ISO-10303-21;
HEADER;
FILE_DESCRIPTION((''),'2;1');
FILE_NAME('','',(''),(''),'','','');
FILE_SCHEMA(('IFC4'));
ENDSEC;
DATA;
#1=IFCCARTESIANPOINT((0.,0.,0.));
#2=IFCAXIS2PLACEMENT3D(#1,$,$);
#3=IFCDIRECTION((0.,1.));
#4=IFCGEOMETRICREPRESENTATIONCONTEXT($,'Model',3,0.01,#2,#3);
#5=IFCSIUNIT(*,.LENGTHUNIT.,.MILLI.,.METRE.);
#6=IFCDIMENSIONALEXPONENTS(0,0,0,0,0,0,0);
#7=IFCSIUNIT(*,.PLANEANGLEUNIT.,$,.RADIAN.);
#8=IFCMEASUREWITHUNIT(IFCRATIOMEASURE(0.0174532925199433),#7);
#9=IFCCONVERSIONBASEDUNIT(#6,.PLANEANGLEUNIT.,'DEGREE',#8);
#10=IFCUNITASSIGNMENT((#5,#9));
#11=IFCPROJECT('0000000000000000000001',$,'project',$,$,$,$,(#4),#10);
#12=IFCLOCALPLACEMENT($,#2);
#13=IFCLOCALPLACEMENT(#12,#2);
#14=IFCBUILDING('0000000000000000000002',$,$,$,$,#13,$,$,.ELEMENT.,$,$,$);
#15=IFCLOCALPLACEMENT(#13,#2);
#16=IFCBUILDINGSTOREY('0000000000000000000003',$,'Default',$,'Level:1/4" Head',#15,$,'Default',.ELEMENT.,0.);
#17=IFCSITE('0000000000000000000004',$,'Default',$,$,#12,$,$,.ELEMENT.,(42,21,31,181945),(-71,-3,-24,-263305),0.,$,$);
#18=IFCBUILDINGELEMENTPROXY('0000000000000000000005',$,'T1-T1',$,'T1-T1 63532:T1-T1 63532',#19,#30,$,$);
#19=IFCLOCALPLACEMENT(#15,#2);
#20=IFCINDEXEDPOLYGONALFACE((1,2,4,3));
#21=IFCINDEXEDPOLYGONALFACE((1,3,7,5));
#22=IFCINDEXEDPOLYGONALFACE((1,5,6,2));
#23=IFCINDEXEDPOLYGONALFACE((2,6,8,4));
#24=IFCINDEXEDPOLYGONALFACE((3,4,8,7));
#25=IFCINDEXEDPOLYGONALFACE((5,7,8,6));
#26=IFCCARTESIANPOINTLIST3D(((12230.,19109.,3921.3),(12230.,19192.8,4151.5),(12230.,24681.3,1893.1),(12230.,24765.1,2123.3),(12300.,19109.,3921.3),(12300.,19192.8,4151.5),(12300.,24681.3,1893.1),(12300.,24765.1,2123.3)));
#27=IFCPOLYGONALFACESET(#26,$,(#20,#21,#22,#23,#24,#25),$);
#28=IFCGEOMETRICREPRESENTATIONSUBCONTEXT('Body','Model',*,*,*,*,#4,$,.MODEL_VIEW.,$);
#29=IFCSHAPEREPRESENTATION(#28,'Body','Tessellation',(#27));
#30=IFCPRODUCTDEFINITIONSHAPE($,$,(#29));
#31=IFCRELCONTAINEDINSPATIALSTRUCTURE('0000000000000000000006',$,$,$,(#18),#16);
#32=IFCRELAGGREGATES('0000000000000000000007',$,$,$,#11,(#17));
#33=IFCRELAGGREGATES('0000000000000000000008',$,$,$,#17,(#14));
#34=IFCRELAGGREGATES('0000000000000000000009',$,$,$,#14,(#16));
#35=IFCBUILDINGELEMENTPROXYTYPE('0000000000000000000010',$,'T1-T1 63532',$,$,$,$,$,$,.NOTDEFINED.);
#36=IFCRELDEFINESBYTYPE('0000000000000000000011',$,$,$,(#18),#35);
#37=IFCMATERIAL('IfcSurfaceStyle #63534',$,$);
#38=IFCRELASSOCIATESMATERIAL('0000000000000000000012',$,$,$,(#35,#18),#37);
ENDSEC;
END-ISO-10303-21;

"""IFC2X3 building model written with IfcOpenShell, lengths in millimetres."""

from ifc_helpers import new_model, entity, si_unit, converted_unit, direction, frame, origin, place, context, subcontext, project, spatial, polyline, outline, extrude, source, transform, mapped, material, type_object, type_shapes, element, save


model = new_model("IFC2X3")

# Units and contexts
model_context = context("Model", 3, precision=0.01, world=origin(), true_north=direction((0.0, 1.0)))
body_context = subcontext(model_context, "Body", "Model", "MODEL_VIEW")
ifc_project = project(units=[si_unit("LENGTHUNIT", "METRE", prefix="MILLI"), converted_unit("PLANEANGLEUNIT", "DEGREE", entity("IfcRatioMeasure", 0.0174532925199433), si_unit("PLANEANGLEUNIT", "RADIAN"), dimensions=[0, 0, 0, 0, 0, 0, 0])], contexts=[model_context])

# Site, building, storey
site_placement = place(None, origin())
site = spatial("IfcSite", under=ifc_project, at=site_placement, Name="Default", CompositionType="ELEMENT", RefLatitude=(42, 21, 31, 181945), RefLongitude=(-71, -3, -24, -263305), RefElevation=0.0)
building_placement = place(site_placement, origin())
building = spatial("IfcBuilding", under=site, at=building_placement, CompositionType="ELEMENT")
storey_placement = place(building_placement, origin())
storey = spatial("IfcBuildingStorey", under=building, at=storey_placement, Name="Default", ObjectType="Level:1/4\" Head", LongName="Default", CompositionType="ELEMENT", Elevation=0.0)

# Building element proxy
ifc_material_1 = material(Name="IfcSurfaceStyle #63534")
building_element_proxy_type_1 = type_object("IfcBuildingElementProxyType", Name="T1-T1 63532", PredefinedType="NOTDEFINED", material=ifc_material_1)
shared_shape_1 = source(origin(), body_context, "Body", "SweptSolid", [
    extrude(outline(polyline([(-2965.0, -122.5), (2965.0, -122.5), (2965.0, 122.5), (-2965.0, 122.5), (-2965.0, -122.5)])), frame((2965.0, 122.5, 0.0), z_axis=(0.0, 0.0, 1.0), x_axis=(-1.0, 0.0, 0.0)), (0.0, 0.0, 1.0), 70.0),
])
type_shapes(building_element_proxy_type_1, [shared_shape_1])
proxy_1_placement = place(building_placement, frame((12300.0, 24681.3, 1893.1), z_axis=(-1.0, 0.0, 0.0), x_axis=(0.0, -0.939693, 0.34202)))
element("IfcBuildingElementProxy", 1, at=proxy_1_placement, inside=storey, type_object=building_element_proxy_type_1, material=ifc_material_1, Name="T1-T1", ObjectType="T1-T1 63532:T1-T1 63532", context=body_context, shape_type="MappedRepresentation", body=[
    mapped(shared_shape_1, transform((0.0, 0.0, 0.0), scale=1.0)),
])

save(model, "model.ifc")
